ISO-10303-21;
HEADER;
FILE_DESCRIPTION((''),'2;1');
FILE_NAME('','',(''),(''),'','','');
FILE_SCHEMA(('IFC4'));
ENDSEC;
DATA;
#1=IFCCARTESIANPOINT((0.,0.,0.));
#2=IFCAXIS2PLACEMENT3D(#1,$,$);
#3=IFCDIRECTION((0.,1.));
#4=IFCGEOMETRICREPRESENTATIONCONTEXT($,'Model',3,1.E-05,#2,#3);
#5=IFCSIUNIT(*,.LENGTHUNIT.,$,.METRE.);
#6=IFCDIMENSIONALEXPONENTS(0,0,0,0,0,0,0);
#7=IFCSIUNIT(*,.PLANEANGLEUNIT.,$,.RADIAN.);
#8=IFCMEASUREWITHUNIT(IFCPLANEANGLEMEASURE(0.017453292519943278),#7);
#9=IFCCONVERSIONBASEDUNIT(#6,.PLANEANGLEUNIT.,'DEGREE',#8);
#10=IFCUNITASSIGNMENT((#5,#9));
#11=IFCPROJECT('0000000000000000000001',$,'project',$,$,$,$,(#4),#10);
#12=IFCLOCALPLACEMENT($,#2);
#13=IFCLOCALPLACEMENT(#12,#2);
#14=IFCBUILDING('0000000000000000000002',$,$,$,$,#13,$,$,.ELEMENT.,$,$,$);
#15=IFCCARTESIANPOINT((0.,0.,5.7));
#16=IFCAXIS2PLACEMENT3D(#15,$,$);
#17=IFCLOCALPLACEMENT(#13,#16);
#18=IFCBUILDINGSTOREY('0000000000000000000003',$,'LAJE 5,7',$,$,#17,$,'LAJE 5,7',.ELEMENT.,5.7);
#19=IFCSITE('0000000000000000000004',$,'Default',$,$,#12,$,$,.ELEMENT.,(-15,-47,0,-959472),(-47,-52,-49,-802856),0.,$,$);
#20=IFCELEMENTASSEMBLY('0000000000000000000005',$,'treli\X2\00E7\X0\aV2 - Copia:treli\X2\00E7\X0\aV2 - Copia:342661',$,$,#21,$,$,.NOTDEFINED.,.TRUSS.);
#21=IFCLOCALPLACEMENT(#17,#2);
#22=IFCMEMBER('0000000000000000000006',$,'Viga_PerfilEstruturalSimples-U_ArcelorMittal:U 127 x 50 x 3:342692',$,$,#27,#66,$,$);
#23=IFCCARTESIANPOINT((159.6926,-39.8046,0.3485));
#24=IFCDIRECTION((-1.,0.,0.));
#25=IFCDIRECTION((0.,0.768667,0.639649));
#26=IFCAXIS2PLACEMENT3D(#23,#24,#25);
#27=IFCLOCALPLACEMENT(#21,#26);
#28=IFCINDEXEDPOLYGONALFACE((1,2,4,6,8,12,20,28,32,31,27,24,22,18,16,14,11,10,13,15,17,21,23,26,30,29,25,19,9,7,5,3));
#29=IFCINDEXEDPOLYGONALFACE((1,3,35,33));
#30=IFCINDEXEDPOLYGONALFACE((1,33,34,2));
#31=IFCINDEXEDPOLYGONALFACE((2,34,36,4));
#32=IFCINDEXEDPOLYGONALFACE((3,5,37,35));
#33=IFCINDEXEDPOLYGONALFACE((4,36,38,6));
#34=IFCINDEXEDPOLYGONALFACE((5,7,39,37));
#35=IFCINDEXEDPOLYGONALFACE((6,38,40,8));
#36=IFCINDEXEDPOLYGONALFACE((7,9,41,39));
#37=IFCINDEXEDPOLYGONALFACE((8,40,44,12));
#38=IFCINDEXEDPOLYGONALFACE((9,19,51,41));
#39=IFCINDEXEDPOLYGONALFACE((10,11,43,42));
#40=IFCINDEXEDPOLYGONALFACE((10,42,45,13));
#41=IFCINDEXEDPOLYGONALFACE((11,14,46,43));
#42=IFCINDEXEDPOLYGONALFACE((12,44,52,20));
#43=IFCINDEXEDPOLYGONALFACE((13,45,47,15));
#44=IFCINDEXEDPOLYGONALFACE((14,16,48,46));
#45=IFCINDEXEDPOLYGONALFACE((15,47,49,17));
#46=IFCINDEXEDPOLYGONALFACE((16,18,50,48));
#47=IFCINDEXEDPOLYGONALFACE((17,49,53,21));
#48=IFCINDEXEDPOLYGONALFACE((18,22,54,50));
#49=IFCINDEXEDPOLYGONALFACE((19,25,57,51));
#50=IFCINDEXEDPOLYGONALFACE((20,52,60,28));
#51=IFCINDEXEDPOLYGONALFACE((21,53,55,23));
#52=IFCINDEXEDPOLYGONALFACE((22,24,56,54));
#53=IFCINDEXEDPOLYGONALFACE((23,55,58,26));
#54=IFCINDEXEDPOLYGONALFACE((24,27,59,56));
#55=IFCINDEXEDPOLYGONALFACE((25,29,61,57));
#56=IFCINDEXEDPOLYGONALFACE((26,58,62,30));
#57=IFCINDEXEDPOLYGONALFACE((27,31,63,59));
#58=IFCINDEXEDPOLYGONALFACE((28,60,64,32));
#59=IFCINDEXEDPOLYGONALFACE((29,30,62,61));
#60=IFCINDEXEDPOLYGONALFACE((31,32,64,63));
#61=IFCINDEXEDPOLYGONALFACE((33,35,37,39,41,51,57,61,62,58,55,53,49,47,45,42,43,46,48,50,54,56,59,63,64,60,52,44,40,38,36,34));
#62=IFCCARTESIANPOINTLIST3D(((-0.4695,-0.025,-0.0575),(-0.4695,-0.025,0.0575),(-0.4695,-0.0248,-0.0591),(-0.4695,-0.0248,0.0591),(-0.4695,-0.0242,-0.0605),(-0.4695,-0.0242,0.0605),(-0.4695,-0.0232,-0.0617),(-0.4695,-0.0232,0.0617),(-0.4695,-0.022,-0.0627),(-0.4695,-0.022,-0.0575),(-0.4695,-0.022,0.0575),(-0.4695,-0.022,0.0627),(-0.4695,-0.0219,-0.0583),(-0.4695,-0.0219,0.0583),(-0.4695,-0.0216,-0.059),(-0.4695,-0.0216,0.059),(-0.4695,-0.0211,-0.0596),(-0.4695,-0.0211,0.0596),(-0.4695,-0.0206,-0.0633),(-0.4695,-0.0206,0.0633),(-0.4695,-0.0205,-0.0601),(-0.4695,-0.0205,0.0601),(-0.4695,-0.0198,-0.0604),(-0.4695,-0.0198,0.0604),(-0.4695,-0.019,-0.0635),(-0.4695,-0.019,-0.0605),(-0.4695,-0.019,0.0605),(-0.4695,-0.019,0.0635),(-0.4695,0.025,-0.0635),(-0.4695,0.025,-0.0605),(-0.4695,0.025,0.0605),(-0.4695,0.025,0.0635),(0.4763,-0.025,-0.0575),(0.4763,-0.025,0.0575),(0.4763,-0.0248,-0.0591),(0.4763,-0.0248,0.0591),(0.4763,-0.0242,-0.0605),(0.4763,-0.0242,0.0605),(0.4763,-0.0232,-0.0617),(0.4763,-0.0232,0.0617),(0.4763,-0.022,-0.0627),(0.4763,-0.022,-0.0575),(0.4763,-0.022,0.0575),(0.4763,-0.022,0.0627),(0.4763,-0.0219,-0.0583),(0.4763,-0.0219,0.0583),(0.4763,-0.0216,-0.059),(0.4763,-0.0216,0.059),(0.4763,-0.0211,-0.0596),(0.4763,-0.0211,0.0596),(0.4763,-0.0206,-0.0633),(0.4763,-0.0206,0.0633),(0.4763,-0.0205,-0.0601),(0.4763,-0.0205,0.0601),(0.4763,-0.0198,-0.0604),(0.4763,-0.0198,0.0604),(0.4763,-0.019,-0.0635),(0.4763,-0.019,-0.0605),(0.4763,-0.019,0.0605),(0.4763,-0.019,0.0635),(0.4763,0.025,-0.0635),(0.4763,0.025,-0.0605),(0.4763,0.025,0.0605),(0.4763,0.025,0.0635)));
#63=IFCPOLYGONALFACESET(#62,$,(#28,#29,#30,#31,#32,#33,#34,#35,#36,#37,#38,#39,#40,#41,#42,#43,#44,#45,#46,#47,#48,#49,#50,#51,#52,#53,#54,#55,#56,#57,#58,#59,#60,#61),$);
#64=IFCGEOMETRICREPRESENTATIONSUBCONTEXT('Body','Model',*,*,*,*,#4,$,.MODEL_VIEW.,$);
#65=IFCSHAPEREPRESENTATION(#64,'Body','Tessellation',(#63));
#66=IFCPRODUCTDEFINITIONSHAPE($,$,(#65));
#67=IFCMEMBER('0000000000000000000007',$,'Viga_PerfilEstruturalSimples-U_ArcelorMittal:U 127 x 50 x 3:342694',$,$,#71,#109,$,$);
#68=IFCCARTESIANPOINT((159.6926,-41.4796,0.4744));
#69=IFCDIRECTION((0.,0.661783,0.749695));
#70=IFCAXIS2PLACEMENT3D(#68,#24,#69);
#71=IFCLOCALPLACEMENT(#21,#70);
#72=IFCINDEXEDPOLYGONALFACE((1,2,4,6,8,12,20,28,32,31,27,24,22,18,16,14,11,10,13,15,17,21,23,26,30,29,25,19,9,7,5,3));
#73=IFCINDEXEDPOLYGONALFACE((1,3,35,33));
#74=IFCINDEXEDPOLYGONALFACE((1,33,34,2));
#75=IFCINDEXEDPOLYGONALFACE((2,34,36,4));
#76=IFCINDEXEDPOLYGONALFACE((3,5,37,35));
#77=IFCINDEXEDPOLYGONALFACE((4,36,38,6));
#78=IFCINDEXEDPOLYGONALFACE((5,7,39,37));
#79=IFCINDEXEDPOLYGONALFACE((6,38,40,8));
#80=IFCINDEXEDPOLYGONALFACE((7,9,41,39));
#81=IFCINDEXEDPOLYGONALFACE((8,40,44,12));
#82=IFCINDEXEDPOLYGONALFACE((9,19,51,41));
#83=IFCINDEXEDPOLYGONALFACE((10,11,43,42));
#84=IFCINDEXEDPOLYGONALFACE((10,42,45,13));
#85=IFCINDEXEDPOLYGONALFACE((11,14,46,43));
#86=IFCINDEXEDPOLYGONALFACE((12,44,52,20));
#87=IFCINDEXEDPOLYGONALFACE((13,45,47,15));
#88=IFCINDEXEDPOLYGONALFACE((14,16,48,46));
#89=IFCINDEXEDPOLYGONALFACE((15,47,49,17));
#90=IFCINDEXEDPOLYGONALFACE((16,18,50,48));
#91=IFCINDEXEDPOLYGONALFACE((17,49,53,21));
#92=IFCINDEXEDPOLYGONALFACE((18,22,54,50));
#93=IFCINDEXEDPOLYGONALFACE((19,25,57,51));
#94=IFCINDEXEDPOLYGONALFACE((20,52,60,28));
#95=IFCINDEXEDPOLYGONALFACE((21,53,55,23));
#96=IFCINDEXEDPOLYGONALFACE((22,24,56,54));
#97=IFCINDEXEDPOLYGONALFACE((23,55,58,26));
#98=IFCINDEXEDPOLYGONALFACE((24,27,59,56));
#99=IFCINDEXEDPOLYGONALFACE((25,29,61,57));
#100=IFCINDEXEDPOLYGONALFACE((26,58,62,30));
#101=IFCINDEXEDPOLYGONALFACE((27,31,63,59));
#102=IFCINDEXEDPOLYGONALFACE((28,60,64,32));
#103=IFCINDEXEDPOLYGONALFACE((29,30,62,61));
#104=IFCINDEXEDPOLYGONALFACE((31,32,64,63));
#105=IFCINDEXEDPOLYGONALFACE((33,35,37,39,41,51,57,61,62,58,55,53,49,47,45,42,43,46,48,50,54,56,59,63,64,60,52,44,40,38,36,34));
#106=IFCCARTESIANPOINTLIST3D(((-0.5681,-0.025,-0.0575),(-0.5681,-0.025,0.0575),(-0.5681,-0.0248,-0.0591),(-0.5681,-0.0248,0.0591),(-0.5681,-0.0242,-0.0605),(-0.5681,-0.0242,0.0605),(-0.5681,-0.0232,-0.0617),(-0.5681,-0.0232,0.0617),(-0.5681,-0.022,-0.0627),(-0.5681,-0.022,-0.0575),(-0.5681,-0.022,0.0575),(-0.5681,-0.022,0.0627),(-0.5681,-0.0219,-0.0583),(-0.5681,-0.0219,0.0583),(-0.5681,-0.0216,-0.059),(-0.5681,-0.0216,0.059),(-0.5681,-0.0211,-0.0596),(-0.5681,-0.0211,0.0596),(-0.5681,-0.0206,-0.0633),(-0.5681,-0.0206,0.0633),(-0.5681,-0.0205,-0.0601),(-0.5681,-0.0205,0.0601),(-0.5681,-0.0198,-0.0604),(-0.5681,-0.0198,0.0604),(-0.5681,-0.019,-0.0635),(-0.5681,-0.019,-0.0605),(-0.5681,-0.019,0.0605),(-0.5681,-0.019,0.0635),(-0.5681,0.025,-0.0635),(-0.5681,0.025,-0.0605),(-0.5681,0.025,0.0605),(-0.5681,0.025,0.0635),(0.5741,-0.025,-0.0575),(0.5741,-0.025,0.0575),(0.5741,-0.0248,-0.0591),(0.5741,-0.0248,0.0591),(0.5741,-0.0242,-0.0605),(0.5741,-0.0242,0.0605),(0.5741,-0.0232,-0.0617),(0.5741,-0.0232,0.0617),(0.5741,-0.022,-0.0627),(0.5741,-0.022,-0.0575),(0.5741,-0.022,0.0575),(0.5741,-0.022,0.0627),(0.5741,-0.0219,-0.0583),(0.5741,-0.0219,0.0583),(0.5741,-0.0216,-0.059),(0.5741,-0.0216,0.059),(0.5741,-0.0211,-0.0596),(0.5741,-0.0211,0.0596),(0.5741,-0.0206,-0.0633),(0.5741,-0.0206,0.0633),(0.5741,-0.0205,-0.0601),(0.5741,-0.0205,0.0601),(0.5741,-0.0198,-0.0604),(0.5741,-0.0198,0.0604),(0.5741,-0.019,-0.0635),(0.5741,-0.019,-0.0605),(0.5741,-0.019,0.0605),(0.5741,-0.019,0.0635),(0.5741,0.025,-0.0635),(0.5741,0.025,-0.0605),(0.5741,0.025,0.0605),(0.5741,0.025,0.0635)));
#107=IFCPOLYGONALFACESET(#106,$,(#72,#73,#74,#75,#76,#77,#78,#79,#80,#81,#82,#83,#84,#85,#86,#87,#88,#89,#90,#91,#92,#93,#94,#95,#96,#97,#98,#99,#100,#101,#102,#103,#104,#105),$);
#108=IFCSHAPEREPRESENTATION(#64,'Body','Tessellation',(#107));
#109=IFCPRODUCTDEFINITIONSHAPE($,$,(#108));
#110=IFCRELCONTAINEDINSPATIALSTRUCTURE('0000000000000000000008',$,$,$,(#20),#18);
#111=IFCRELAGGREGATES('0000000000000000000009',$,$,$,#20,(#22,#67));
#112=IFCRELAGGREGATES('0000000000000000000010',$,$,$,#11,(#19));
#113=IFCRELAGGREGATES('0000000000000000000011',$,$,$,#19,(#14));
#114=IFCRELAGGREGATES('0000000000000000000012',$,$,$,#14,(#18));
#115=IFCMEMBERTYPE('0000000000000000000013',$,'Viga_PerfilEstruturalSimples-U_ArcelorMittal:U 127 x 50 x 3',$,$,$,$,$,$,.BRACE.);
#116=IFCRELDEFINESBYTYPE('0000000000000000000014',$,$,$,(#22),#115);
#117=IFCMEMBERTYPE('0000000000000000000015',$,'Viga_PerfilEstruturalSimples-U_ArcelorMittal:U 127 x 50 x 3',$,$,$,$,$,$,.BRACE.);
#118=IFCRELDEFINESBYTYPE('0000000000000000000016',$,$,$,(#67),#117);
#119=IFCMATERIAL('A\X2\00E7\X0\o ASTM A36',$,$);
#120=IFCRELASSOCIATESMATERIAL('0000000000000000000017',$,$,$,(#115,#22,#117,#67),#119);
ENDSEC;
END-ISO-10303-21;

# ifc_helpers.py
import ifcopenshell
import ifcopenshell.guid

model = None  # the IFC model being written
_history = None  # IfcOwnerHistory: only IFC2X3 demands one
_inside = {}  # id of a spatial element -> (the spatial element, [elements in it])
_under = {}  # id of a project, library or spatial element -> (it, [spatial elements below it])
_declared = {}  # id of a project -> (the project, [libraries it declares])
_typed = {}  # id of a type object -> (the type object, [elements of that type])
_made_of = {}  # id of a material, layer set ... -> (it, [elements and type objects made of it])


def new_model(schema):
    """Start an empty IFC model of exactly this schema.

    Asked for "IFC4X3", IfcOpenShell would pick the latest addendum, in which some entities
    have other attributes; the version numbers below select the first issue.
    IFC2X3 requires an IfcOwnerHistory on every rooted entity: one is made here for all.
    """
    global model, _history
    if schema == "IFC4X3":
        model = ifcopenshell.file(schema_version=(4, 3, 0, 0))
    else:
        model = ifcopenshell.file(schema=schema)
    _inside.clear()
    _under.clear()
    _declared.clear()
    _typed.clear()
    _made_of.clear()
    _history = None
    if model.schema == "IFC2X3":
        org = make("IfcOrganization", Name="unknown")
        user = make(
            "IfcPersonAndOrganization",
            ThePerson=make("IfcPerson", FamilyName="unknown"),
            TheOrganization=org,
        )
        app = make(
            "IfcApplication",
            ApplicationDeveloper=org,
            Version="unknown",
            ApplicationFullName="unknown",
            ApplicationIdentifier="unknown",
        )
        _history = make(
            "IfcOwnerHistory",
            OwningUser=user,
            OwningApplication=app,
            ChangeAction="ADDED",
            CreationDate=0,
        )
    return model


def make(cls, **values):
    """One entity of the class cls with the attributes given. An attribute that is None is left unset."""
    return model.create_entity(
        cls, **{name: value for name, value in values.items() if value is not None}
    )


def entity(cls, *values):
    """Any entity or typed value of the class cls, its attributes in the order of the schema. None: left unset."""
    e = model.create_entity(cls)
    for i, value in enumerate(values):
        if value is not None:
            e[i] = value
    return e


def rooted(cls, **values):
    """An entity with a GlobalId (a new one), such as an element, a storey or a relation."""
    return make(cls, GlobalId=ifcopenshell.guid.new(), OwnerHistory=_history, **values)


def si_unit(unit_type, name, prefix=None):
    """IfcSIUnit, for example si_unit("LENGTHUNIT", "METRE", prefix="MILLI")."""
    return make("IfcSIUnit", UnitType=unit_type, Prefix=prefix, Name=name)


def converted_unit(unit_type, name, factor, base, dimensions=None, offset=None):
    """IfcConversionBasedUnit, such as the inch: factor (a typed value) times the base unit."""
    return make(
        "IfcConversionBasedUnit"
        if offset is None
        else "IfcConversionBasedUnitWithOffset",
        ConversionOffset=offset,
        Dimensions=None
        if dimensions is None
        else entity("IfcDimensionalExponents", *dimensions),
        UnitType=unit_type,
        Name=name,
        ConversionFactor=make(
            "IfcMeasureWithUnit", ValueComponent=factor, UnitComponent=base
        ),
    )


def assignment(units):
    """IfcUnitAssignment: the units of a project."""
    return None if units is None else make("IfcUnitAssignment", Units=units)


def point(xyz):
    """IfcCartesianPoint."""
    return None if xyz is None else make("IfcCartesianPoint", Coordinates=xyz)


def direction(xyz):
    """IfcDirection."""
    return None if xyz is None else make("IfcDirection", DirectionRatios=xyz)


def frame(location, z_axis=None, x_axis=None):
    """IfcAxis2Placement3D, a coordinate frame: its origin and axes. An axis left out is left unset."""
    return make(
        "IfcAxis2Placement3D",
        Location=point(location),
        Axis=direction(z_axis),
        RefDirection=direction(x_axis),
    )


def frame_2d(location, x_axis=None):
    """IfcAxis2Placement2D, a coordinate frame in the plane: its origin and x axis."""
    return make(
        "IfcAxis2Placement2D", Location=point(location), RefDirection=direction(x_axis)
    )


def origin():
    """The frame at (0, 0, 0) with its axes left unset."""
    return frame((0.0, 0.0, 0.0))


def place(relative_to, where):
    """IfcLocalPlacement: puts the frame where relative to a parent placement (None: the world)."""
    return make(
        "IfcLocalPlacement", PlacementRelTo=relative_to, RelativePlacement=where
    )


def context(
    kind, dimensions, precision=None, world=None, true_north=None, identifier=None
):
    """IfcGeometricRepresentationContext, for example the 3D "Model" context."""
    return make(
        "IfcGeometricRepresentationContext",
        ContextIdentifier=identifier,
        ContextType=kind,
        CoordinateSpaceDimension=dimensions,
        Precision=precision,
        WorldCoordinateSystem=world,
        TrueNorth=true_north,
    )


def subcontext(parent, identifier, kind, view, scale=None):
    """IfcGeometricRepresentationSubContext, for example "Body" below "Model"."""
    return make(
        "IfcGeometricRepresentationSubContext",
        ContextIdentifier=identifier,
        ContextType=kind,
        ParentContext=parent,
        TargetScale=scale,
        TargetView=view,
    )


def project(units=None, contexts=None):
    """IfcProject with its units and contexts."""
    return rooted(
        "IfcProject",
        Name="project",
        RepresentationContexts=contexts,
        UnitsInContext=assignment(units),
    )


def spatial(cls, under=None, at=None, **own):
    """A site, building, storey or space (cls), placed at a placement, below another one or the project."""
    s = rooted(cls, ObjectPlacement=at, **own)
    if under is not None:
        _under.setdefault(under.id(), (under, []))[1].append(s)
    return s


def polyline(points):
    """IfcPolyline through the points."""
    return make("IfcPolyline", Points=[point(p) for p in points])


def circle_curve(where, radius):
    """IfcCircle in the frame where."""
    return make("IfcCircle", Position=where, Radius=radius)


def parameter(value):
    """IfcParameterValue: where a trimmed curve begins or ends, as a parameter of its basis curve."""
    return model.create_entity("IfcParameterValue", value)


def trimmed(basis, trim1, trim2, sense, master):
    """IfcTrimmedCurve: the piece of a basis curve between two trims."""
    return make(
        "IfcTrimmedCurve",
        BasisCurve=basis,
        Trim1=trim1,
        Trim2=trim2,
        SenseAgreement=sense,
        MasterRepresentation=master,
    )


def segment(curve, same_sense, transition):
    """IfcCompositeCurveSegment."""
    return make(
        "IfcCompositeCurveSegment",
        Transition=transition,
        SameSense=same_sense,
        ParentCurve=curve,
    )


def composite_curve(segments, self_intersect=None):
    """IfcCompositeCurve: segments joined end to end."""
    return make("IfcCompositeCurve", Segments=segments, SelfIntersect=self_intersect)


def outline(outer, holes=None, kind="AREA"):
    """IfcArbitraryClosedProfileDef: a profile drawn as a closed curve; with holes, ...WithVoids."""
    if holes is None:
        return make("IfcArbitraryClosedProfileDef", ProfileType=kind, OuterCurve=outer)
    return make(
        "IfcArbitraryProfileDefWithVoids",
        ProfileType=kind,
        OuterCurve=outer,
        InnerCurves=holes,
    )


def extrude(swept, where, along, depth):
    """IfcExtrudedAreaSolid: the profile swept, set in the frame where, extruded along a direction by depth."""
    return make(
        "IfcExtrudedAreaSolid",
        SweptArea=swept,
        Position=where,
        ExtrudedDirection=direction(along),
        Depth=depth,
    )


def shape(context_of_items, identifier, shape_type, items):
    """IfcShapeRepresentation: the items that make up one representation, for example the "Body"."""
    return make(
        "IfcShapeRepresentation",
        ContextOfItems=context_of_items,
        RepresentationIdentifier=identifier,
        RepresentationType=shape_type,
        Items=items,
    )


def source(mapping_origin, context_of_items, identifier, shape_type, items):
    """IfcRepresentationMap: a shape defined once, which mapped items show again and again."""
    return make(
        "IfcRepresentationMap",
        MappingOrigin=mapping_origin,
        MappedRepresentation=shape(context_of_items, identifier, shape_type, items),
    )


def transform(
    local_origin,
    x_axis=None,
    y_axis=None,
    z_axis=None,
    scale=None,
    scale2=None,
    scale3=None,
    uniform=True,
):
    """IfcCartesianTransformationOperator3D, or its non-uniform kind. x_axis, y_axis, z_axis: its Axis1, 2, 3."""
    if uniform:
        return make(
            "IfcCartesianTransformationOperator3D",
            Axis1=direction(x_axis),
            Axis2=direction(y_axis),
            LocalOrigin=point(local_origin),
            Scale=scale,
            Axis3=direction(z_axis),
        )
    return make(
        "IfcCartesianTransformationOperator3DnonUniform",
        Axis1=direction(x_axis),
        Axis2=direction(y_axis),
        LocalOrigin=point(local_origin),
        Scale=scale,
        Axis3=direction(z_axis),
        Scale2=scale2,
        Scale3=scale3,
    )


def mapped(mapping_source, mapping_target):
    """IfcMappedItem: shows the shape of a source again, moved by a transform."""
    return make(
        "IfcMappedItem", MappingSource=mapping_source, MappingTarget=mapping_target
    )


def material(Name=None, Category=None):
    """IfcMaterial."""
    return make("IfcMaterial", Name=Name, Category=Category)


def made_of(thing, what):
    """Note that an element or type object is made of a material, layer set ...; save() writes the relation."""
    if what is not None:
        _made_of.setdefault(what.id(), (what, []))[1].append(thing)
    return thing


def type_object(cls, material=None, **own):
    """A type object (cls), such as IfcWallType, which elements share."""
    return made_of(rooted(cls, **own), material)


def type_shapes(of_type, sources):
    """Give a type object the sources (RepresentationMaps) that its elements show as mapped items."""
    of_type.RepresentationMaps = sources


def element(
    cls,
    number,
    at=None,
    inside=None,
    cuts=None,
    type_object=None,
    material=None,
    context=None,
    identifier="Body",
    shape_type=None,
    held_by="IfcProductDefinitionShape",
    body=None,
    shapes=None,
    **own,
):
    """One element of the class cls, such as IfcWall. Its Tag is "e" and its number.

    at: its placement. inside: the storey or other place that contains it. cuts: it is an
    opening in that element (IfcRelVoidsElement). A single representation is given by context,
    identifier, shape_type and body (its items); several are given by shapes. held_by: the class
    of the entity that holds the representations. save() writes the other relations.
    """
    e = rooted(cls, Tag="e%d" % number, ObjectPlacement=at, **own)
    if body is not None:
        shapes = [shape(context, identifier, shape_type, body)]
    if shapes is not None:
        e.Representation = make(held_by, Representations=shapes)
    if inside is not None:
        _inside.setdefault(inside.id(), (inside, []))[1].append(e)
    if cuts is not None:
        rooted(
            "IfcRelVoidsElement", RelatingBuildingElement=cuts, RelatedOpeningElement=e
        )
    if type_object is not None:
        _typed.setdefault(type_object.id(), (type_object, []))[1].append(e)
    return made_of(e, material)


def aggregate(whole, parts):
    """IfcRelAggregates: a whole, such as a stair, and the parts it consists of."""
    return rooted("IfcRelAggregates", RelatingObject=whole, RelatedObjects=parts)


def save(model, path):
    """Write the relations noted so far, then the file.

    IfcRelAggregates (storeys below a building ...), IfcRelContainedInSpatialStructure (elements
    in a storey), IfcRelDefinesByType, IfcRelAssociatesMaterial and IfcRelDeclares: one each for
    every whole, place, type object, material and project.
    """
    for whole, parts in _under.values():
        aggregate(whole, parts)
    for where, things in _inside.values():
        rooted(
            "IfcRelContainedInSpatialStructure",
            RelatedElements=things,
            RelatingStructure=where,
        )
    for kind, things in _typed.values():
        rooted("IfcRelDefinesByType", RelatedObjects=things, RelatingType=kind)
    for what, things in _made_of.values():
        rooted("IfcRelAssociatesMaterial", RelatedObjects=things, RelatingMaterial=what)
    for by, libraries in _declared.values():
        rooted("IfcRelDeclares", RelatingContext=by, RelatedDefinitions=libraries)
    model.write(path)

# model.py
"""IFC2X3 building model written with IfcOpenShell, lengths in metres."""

from ifc_helpers import new_model, entity, si_unit, converted_unit, direction, frame, frame_2d, origin, place, context, subcontext, project, spatial, polyline, circle_curve, parameter, trimmed, segment, composite_curve, outline, extrude, source, transform, mapped, material, type_object, type_shapes, element, aggregate, save


model = new_model("IFC2X3")

# Units and contexts
model_context = context("Model", 3, precision=1e-05, world=origin(), true_north=direction((0.0, 1.0)))
body_context = subcontext(model_context, "Body", "Model", "MODEL_VIEW")
ifc_project = project(units=[si_unit("LENGTHUNIT", "METRE"), converted_unit("PLANEANGLEUNIT", "DEGREE", entity("IfcPlaneAngleMeasure", 0.017453292519943278), si_unit("PLANEANGLEUNIT", "RADIAN"), dimensions=[0, 0, 0, 0, 0, 0, 0])], contexts=[model_context])

# Site, building, storey
site_placement = place(None, origin())
site = spatial("IfcSite", under=ifc_project, at=site_placement, Name="Default", CompositionType="ELEMENT", RefLatitude=(-15, -47, 0, -959472), RefLongitude=(-47, -52, -49, -802856), RefElevation=0.0)
building_placement = place(site_placement, origin())
building = spatial("IfcBuilding", under=site, at=building_placement, CompositionType="ELEMENT")
storey_placement = place(building_placement, frame((0.0, 0.0, 5.7)))
storey = spatial("IfcBuildingStorey", under=building, at=storey_placement, Name="LAJE 5,7", LongName="LAJE 5,7", CompositionType="ELEMENT", Elevation=5.7)

# Element assembly
ifc_material = material(Name="Aço ASTM A36")
assembly_1_placement = place(storey_placement, origin())
assembly_1 = element("IfcElementAssembly", 1, at=assembly_1_placement, inside=storey, Name="treliçaV2 - Copia:treliçaV2 - Copia:342661", AssemblyPlace="NOTDEFINED", PredefinedType="TRUSS")

# Members
member_type_1 = type_object("IfcMemberType", Name="Viga_PerfilEstruturalSimples-U_ArcelorMittal:U 127 x 50 x 3", PredefinedType="BRACE", material=ifc_material)
shared_shape_1 = source(origin(), body_context, "Body", "SweptSolid", [
    extrude(outline(composite_curve([segment(polyline([(-0.0575, -0.0192), (0.0575, -0.0192)]), True, "CONTINUOUS"), segment(trimmed(circle_curve(frame_2d((0.0575, -0.0132), x_axis=(0.0, 1.0)), 0.006), [parameter(180.0)], [parameter(270.0)], True, "PARAMETER"), True, "CONTINUOUS"), segment(polyline([(0.0635, -0.0132), (0.0635, 0.0308)]), True, "CONTINUOUS"), segment(polyline([(0.0635, 0.0308), (0.0605, 0.0308)]), True, "CONTINUOUS"), segment(polyline([(0.0605, 0.0308), (0.0605, -0.0132)]), True, "CONTINUOUS"), segment(trimmed(circle_curve(frame_2d((0.0575, -0.0132), x_axis=(0.0, 1.0)), 0.003), [parameter(180.0)], [parameter(270.0)], True, "PARAMETER"), False, "CONTINUOUS"), segment(polyline([(0.0575, -0.0162), (-0.0575, -0.0162)]), True, "CONTINUOUS"), segment(trimmed(circle_curve(frame_2d((-0.0575, -0.0132), x_axis=(0.0, 1.0)), 0.003), [parameter(90.0)], [parameter(180.0)], True, "PARAMETER"), False, "CONTINUOUS"), segment(polyline([(-0.0605, -0.0132), (-0.0605, 0.0308)]), True, "CONTINUOUS"), segment(polyline([(-0.0605, 0.0308), (-0.0635, 0.0308)]), True, "CONTINUOUS"), segment(polyline([(-0.0635, 0.0308), (-0.0635, -0.0132)]), True, "CONTINUOUS"), segment(trimmed(circle_curve(frame_2d((-0.0575, -0.0132), x_axis=(0.0, 1.0)), 0.006), [parameter(90.0)], [parameter(180.0)], True, "PARAMETER"), True, "CONTINUOUS")], self_intersect=False)), frame((-0.4695, -0.0058, 0.0), z_axis=(1.0, 0.0, 0.0), x_axis=(0.0, 0.0, -1.0)), (0.0, 0.0, 1.0), 0.9459),
])
type_shapes(member_type_1, [shared_shape_1])
member_1_placement = place(assembly_1_placement, frame((159.6926, -39.8046, 0.3485), z_axis=(-1.0, 0.0, 0.0), x_axis=(0.0, 0.768667, 0.639649)))
member_1 = element("IfcMember", 2, at=member_1_placement, type_object=member_type_1, material=ifc_material, Name="Viga_PerfilEstruturalSimples-U_ArcelorMittal:U 127 x 50 x 3:342692", context=body_context, shape_type="MappedRepresentation", body=[
    mapped(shared_shape_1, transform((0.0, 0.0, 0.0), scale=1.0)),
])
member_type_2 = type_object("IfcMemberType", Name="Viga_PerfilEstruturalSimples-U_ArcelorMittal:U 127 x 50 x 3", PredefinedType="BRACE", material=ifc_material)
shared_shape_2 = source(origin(), body_context, "Body", "SweptSolid", [
    extrude(outline(composite_curve([segment(polyline([(-0.0575, -0.0192), (0.0575, -0.0192)]), True, "CONTINUOUS"), segment(trimmed(circle_curve(frame_2d((0.0575, -0.0132), x_axis=(0.0, 1.0)), 0.006), [parameter(180.0)], [parameter(270.0)], True, "PARAMETER"), True, "CONTINUOUS"), segment(polyline([(0.0635, -0.0132), (0.0635, 0.0308)]), True, "CONTINUOUS"), segment(polyline([(0.0635, 0.0308), (0.0605, 0.0308)]), True, "CONTINUOUS"), segment(polyline([(0.0605, 0.0308), (0.0605, -0.0132)]), True, "CONTINUOUS"), segment(trimmed(circle_curve(frame_2d((0.0575, -0.0132), x_axis=(0.0, 1.0)), 0.003), [parameter(180.0)], [parameter(270.0)], True, "PARAMETER"), False, "CONTINUOUS"), segment(polyline([(0.0575, -0.0162), (-0.0575, -0.0162)]), True, "CONTINUOUS"), segment(trimmed(circle_curve(frame_2d((-0.0575, -0.0132), x_axis=(0.0, 1.0)), 0.003), [parameter(90.0)], [parameter(180.0)], True, "PARAMETER"), False, "CONTINUOUS"), segment(polyline([(-0.0605, -0.0132), (-0.0605, 0.0308)]), True, "CONTINUOUS"), segment(polyline([(-0.0605, 0.0308), (-0.0635, 0.0308)]), True, "CONTINUOUS"), segment(polyline([(-0.0635, 0.0308), (-0.0635, -0.0132)]), True, "CONTINUOUS"), segment(trimmed(circle_curve(frame_2d((-0.0575, -0.0132), x_axis=(0.0, 1.0)), 0.006), [parameter(90.0)], [parameter(180.0)], True, "PARAMETER"), True, "CONTINUOUS")], self_intersect=False)), frame((-0.5681, -0.0058, 0.0), z_axis=(1.0, 0.0, 0.0), x_axis=(0.0, 0.0, -1.0)), (0.0, 0.0, 1.0), 1.1422),
])
type_shapes(member_type_2, [shared_shape_2])
member_2_placement = place(assembly_1_placement, frame((159.6926, -41.4796, 0.4744), z_axis=(-1.0, 0.0, 0.0), x_axis=(0.0, 0.661783, 0.749695)))
member_2 = element("IfcMember", 3, at=member_2_placement, type_object=member_type_2, material=ifc_material, Name="Viga_PerfilEstruturalSimples-U_ArcelorMittal:U 127 x 50 x 3:342694", context=body_context, shape_type="MappedRepresentation", body=[
    mapped(shared_shape_2, transform((0.0, 0.0, 0.0), scale=1.0)),
])
aggregate(assembly_1, [member_1, member_2])

save(model, "model.ifc")
